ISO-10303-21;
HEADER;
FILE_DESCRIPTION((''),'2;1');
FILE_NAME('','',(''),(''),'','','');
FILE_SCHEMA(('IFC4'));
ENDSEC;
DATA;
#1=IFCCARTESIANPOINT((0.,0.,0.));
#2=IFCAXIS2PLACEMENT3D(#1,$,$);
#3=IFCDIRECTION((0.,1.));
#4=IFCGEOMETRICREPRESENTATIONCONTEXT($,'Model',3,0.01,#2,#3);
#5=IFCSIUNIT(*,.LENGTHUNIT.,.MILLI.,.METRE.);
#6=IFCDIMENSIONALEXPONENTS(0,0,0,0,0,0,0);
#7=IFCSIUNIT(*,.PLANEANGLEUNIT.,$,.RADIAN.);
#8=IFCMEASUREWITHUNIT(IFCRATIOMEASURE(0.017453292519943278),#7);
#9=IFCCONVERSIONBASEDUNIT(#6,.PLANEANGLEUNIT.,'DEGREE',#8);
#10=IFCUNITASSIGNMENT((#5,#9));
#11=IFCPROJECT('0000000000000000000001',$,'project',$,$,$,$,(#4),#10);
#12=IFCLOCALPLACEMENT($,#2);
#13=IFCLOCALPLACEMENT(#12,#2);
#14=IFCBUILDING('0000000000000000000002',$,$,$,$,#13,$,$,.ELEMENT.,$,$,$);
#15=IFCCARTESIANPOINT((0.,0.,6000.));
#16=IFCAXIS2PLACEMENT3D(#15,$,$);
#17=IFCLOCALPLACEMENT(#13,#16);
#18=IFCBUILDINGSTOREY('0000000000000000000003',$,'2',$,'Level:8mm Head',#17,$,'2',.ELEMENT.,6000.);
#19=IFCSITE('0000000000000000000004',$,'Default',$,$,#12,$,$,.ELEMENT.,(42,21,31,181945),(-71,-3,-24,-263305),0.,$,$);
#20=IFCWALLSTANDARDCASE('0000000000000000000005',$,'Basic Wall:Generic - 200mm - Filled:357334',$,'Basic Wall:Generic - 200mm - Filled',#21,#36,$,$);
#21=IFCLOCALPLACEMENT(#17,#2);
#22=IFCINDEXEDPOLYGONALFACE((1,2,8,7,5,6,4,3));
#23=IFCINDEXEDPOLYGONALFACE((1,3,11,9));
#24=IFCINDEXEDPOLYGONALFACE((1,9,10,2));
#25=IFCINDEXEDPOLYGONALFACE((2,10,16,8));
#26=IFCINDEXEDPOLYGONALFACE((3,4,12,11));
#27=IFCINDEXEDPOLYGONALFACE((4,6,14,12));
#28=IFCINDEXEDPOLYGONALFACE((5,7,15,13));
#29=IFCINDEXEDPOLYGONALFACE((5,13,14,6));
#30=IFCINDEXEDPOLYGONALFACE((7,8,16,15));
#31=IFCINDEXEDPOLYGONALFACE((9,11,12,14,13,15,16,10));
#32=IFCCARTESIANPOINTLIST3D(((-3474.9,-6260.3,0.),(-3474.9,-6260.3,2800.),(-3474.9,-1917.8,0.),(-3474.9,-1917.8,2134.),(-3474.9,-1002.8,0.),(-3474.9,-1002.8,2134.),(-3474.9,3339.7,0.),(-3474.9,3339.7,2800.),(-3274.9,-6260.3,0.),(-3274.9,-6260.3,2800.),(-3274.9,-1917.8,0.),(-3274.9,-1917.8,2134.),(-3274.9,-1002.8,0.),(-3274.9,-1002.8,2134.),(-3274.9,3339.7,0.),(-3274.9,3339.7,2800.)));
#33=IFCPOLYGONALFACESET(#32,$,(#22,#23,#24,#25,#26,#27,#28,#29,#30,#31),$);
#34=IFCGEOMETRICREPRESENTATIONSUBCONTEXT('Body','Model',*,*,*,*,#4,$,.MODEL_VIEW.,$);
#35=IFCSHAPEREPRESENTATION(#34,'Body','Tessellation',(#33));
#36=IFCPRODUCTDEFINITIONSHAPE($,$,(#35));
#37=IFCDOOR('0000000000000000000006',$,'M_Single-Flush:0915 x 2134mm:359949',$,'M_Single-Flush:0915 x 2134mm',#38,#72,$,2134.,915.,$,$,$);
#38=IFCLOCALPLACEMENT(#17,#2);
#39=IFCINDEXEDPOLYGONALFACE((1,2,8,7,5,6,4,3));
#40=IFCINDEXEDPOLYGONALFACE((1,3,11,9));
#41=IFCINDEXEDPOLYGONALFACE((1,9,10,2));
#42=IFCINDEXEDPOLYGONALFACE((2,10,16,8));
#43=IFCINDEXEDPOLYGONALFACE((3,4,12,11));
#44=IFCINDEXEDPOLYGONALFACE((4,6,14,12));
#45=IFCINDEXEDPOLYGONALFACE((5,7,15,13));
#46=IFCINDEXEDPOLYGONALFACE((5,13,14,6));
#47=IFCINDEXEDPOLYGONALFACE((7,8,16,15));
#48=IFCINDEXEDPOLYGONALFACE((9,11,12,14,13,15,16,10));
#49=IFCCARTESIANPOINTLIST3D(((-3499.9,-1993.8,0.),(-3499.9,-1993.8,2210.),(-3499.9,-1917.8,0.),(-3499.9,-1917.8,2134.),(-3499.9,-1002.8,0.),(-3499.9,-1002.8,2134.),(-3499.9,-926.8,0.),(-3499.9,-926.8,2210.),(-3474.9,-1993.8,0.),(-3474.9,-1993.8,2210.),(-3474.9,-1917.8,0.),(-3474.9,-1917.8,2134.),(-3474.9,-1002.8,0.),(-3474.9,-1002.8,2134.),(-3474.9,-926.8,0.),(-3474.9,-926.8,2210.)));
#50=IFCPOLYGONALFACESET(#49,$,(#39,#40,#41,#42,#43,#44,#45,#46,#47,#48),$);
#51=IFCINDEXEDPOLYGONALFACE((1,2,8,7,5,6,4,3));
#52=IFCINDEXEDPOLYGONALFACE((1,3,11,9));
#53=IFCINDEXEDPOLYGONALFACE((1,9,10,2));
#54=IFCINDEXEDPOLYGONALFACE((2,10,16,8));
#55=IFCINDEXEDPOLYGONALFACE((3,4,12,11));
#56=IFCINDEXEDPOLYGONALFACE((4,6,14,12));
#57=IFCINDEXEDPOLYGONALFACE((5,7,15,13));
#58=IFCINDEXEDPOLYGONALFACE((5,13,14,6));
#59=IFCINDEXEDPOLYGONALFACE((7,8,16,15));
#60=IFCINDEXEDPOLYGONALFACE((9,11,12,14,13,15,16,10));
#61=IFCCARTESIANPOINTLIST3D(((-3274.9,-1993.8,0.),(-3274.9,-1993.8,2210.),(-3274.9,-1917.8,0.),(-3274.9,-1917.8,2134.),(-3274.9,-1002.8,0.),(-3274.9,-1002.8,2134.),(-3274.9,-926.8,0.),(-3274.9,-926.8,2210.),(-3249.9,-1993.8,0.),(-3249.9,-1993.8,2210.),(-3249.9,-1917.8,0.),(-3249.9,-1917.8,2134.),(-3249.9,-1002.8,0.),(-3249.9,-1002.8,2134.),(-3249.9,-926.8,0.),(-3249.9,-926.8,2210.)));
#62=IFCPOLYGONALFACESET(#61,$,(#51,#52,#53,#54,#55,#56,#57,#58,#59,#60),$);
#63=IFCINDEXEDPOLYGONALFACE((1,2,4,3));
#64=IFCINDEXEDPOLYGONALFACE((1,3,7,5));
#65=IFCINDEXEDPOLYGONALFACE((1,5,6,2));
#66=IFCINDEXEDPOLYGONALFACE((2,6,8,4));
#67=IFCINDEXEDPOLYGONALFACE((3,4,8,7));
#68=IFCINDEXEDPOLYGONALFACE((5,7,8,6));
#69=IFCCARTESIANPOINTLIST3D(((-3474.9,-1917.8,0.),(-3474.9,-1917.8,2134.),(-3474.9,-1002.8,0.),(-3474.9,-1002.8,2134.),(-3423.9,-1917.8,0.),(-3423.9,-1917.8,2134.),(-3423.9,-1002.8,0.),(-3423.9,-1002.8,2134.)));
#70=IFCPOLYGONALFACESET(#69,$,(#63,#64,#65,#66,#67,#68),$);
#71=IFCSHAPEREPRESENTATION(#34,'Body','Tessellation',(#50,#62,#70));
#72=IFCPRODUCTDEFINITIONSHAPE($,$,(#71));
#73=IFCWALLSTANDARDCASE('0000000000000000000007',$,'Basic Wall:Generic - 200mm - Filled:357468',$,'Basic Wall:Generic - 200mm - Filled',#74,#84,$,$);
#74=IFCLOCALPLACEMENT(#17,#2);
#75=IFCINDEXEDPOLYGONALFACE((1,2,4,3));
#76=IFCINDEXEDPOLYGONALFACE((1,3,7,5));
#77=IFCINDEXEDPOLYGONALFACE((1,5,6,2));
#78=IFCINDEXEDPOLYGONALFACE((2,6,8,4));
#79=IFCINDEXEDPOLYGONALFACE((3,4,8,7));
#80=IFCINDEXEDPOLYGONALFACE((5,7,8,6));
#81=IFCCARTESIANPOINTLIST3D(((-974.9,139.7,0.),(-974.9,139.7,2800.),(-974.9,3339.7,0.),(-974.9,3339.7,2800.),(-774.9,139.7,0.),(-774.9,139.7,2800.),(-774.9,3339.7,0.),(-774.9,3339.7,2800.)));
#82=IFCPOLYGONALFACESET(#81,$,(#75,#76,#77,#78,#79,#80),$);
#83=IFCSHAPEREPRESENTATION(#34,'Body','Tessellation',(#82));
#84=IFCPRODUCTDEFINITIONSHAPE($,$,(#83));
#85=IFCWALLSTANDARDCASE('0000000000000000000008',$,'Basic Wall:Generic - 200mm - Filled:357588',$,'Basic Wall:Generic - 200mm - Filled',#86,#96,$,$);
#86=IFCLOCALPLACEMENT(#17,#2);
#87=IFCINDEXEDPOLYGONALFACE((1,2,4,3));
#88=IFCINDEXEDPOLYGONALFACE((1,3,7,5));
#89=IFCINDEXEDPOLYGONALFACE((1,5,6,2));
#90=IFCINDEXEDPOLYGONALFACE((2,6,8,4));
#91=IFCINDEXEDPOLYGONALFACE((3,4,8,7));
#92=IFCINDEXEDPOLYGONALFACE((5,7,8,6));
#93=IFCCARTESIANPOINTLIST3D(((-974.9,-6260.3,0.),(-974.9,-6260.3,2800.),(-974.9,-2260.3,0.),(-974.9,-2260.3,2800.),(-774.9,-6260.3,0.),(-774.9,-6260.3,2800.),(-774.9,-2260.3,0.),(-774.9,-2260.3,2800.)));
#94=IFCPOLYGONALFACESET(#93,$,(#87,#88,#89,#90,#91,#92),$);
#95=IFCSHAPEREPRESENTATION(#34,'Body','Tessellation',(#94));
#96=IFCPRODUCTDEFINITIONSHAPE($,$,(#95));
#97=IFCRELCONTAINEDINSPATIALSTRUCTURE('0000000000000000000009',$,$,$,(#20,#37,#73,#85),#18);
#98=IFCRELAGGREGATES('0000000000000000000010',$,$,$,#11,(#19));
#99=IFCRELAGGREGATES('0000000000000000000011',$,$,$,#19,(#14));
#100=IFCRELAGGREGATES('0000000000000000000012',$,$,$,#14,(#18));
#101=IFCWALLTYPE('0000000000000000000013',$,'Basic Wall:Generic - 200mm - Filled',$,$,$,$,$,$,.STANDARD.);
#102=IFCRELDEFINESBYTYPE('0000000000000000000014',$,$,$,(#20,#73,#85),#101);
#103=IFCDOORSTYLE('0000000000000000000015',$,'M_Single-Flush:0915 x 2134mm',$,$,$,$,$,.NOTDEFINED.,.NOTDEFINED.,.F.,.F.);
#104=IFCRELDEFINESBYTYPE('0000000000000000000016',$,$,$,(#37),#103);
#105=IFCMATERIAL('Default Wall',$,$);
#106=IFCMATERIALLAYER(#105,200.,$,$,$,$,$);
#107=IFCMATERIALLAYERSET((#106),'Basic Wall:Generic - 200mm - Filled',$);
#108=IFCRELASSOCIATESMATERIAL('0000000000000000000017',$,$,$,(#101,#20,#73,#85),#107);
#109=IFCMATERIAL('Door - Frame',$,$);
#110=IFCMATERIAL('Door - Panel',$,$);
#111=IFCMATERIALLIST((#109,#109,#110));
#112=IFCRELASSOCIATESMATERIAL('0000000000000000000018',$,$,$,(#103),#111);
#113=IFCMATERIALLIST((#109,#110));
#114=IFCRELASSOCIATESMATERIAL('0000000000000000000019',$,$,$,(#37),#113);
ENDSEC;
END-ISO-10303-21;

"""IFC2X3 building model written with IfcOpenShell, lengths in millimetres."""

from ifc_helpers import new_model, entity, si_unit, converted_unit, direction, frame, frame_2d, origin, place, context, subcontext, project, spatial, polyline, rectangle, outline, extrude, source, transform, mapped, material, material_list, layer, layer_set, layer_usage, type_object, type_shapes, element, fill, save


model = new_model("IFC2X3")

# Units and contexts
model_context = context("Model", 3, precision=0.01, world=origin(), true_north=direction((0.0, 1.0)))
body_context = subcontext(model_context, "Body", "Model", "MODEL_VIEW")
ifc_project = project(units=[si_unit("LENGTHUNIT", "METRE", prefix="MILLI"), converted_unit("PLANEANGLEUNIT", "DEGREE", entity("IfcRatioMeasure", 0.017453292519943278), si_unit("PLANEANGLEUNIT", "RADIAN"), dimensions=[0, 0, 0, 0, 0, 0, 0])], contexts=[model_context])

# Site, building, storey
site_placement = place(None, origin())
site = spatial("IfcSite", under=ifc_project, at=site_placement, Name="Default", CompositionType="ELEMENT", RefLatitude=(42, 21, 31, 181945), RefLongitude=(-71, -3, -24, -263305), RefElevation=0.0)
building_placement = place(site_placement, origin())
building = spatial("IfcBuilding", under=site, at=building_placement, CompositionType="ELEMENT")
storey_placement = place(building_placement, frame((0.0, 0.0, 6000.0)))
storey = spatial("IfcBuildingStorey", under=building, at=storey_placement, Name="2", ObjectType="Level:8mm Head", LongName="2", CompositionType="ELEMENT", Elevation=6000.0)

# Wall, opening, door
ifc_material_1 = material(Name="Default Wall")
ifc_layer_1 = layer(ifc_material_1, 200.0)
ifc_layer_set_1 = layer_set([ifc_layer_1], Name="Basic Wall:Generic - 200mm - Filled")
ifc_layer_usage_1 = layer_usage(ifc_layer_set_1, "AXIS2", "NEGATIVE", 100.0)
wall_type_1 = type_object("IfcWallType", Name="Basic Wall:Generic - 200mm - Filled", PredefinedType="STANDARD", material=ifc_layer_set_1)
wall_1_placement = place(storey_placement, frame((-3374.9, 3339.7, 0.0), z_axis=(0.0, 0.0, 1.0), x_axis=(0.0, -1.0, 0.0)))
wall_1 = element("IfcWallStandardCase", 1, at=wall_1_placement, inside=storey, type_object=wall_type_1, material=ifc_layer_usage_1, Name="Basic Wall:Generic - 200mm - Filled:357334", ObjectType="Basic Wall:Generic - 200mm - Filled", context=body_context, shape_type="SweptSolid", body=[
    extrude(rectangle(XDim=9600.0, YDim=200.0, at=frame_2d((4800.0, 0.0), x_axis=(1.0, 0.0))), origin(), (0.0, 0.0, 1.0), 2800.0),
])
opening_1_placement = place(wall_1_placement, frame((5257.5, 100.0, 0.0)))
opening_1 = element("IfcOpeningElement", 2, at=opening_1_placement, cuts=wall_1, ObjectType="Opening", context=body_context, shape_type="SweptSolid", body=[
    extrude(rectangle(XDim=915.0, YDim=2134.0, at=frame_2d((1067.0, 457.5), x_axis=(0.0, 1.0))), frame((0.0, 0.0, 0.0), z_axis=(0.0, -1.0, 0.0), x_axis=(0.0, 0.0, 1.0)), (0.0, 0.0, 1.0), 200.0),
])
ifc_material_2 = material(Name="Door - Frame")
ifc_material_3 = material(Name="Door - Panel")
ifc_material_list_1 = material_list([ifc_material_2, ifc_material_3])
ifc_material_list_2 = material_list([ifc_material_2, ifc_material_2, ifc_material_3])
door_style_1 = type_object("IfcDoorStyle", Name="M_Single-Flush:0915 x 2134mm", ConstructionType="NOTDEFINED", OperationType="NOTDEFINED", ParameterTakesPrecedence=False, Sizeable=False, material=ifc_material_list_2)
shared_shape_1 = source(origin(), body_context, "Body", "SweptSolid", [
    extrude(outline(polyline([(-533.5, -1124.0), (533.5, -1124.0), (533.5, 1086.0), (457.5, 1086.0), (457.5, -1048.0), (-457.5, -1048.0), (-457.5, 1086.0), (-533.5, 1086.0), (-533.5, -1124.0)])), frame((457.5, 200.0, 1086.0), z_axis=(0.0, 1.0, 0.0), x_axis=(1.0, 0.0, 0.0)), (0.0, 0.0, 1.0), 25.0),
    extrude(outline(polyline([(-1124.0, -533.5), (1086.0, -533.5), (1086.0, -457.5), (-1048.0, -457.5), (-1048.0, 457.5), (1086.0, 457.5), (1086.0, 533.5), (-1124.0, 533.5), (-1124.0, -533.5)])), frame((457.5, -25.0, 1086.0), z_axis=(0.0, 1.0, 0.0), x_axis=(0.0, 0.0, -1.0)), (0.0, 0.0, 1.0), 25.0),
    extrude(rectangle(XDim=51.0, YDim=915.0, at=frame_2d((0.0, 0.0), x_axis=(1.0, 0.0))), frame((457.5, 174.5, 0.0), z_axis=(0.0, 0.0, 1.0), x_axis=(0.0, 1.0, 0.0)), (0.0, 0.0, 1.0), 2134.0),
])
type_shapes(door_style_1, [shared_shape_1])
door_1_placement = place(opening_1_placement, frame((0.0, 0.0, 0.0), z_axis=(0.0, 0.0, 1.0), x_axis=(-1.0, 0.0, 0.0)))
door_1 = element("IfcDoor", 3, at=door_1_placement, inside=storey, type_object=door_style_1, material=ifc_material_list_1, Name="M_Single-Flush:0915 x 2134mm:359949", ObjectType="M_Single-Flush:0915 x 2134mm", OverallHeight=2134.0, OverallWidth=915.0, context=body_context, shape_type="MappedRepresentation", body=[
    mapped(shared_shape_1, transform((0.0, 0.0, 0.0), scale=1.0)),
])
fill(opening_1, door_1)

# Walls
wall_2_placement = place(storey_placement, frame((-874.9, 3339.7, 0.0), z_axis=(0.0, 0.0, 1.0), x_axis=(0.0, -1.0, 0.0)))
element("IfcWallStandardCase", 4, at=wall_2_placement, inside=storey, type_object=wall_type_1, material=ifc_layer_usage_1, Name="Basic Wall:Generic - 200mm - Filled:357468", ObjectType="Basic Wall:Generic - 200mm - Filled", context=body_context, shape_type="SweptSolid", body=[
    extrude(rectangle(XDim=3200.0, YDim=200.0, at=frame_2d((1600.0, 0.0), x_axis=(-1.0, 0.0))), origin(), (0.0, 0.0, 1.0), 2800.0),
])
wall_3_placement = place(storey_placement, frame((-874.9, -2260.3, 0.0), z_axis=(0.0, 0.0, 1.0), x_axis=(0.0, -1.0, 0.0)))
element("IfcWallStandardCase", 5, at=wall_3_placement, inside=storey, type_object=wall_type_1, material=ifc_layer_usage_1, Name="Basic Wall:Generic - 200mm - Filled:357588", ObjectType="Basic Wall:Generic - 200mm - Filled", context=body_context, shape_type="SweptSolid", body=[
    extrude(rectangle(XDim=4000.0, YDim=200.0, at=frame_2d((2000.0, 0.0), x_axis=(-1.0, 0.0))), origin(), (0.0, 0.0, 1.0), 2800.0),
])

save(model, "model.ifc")
